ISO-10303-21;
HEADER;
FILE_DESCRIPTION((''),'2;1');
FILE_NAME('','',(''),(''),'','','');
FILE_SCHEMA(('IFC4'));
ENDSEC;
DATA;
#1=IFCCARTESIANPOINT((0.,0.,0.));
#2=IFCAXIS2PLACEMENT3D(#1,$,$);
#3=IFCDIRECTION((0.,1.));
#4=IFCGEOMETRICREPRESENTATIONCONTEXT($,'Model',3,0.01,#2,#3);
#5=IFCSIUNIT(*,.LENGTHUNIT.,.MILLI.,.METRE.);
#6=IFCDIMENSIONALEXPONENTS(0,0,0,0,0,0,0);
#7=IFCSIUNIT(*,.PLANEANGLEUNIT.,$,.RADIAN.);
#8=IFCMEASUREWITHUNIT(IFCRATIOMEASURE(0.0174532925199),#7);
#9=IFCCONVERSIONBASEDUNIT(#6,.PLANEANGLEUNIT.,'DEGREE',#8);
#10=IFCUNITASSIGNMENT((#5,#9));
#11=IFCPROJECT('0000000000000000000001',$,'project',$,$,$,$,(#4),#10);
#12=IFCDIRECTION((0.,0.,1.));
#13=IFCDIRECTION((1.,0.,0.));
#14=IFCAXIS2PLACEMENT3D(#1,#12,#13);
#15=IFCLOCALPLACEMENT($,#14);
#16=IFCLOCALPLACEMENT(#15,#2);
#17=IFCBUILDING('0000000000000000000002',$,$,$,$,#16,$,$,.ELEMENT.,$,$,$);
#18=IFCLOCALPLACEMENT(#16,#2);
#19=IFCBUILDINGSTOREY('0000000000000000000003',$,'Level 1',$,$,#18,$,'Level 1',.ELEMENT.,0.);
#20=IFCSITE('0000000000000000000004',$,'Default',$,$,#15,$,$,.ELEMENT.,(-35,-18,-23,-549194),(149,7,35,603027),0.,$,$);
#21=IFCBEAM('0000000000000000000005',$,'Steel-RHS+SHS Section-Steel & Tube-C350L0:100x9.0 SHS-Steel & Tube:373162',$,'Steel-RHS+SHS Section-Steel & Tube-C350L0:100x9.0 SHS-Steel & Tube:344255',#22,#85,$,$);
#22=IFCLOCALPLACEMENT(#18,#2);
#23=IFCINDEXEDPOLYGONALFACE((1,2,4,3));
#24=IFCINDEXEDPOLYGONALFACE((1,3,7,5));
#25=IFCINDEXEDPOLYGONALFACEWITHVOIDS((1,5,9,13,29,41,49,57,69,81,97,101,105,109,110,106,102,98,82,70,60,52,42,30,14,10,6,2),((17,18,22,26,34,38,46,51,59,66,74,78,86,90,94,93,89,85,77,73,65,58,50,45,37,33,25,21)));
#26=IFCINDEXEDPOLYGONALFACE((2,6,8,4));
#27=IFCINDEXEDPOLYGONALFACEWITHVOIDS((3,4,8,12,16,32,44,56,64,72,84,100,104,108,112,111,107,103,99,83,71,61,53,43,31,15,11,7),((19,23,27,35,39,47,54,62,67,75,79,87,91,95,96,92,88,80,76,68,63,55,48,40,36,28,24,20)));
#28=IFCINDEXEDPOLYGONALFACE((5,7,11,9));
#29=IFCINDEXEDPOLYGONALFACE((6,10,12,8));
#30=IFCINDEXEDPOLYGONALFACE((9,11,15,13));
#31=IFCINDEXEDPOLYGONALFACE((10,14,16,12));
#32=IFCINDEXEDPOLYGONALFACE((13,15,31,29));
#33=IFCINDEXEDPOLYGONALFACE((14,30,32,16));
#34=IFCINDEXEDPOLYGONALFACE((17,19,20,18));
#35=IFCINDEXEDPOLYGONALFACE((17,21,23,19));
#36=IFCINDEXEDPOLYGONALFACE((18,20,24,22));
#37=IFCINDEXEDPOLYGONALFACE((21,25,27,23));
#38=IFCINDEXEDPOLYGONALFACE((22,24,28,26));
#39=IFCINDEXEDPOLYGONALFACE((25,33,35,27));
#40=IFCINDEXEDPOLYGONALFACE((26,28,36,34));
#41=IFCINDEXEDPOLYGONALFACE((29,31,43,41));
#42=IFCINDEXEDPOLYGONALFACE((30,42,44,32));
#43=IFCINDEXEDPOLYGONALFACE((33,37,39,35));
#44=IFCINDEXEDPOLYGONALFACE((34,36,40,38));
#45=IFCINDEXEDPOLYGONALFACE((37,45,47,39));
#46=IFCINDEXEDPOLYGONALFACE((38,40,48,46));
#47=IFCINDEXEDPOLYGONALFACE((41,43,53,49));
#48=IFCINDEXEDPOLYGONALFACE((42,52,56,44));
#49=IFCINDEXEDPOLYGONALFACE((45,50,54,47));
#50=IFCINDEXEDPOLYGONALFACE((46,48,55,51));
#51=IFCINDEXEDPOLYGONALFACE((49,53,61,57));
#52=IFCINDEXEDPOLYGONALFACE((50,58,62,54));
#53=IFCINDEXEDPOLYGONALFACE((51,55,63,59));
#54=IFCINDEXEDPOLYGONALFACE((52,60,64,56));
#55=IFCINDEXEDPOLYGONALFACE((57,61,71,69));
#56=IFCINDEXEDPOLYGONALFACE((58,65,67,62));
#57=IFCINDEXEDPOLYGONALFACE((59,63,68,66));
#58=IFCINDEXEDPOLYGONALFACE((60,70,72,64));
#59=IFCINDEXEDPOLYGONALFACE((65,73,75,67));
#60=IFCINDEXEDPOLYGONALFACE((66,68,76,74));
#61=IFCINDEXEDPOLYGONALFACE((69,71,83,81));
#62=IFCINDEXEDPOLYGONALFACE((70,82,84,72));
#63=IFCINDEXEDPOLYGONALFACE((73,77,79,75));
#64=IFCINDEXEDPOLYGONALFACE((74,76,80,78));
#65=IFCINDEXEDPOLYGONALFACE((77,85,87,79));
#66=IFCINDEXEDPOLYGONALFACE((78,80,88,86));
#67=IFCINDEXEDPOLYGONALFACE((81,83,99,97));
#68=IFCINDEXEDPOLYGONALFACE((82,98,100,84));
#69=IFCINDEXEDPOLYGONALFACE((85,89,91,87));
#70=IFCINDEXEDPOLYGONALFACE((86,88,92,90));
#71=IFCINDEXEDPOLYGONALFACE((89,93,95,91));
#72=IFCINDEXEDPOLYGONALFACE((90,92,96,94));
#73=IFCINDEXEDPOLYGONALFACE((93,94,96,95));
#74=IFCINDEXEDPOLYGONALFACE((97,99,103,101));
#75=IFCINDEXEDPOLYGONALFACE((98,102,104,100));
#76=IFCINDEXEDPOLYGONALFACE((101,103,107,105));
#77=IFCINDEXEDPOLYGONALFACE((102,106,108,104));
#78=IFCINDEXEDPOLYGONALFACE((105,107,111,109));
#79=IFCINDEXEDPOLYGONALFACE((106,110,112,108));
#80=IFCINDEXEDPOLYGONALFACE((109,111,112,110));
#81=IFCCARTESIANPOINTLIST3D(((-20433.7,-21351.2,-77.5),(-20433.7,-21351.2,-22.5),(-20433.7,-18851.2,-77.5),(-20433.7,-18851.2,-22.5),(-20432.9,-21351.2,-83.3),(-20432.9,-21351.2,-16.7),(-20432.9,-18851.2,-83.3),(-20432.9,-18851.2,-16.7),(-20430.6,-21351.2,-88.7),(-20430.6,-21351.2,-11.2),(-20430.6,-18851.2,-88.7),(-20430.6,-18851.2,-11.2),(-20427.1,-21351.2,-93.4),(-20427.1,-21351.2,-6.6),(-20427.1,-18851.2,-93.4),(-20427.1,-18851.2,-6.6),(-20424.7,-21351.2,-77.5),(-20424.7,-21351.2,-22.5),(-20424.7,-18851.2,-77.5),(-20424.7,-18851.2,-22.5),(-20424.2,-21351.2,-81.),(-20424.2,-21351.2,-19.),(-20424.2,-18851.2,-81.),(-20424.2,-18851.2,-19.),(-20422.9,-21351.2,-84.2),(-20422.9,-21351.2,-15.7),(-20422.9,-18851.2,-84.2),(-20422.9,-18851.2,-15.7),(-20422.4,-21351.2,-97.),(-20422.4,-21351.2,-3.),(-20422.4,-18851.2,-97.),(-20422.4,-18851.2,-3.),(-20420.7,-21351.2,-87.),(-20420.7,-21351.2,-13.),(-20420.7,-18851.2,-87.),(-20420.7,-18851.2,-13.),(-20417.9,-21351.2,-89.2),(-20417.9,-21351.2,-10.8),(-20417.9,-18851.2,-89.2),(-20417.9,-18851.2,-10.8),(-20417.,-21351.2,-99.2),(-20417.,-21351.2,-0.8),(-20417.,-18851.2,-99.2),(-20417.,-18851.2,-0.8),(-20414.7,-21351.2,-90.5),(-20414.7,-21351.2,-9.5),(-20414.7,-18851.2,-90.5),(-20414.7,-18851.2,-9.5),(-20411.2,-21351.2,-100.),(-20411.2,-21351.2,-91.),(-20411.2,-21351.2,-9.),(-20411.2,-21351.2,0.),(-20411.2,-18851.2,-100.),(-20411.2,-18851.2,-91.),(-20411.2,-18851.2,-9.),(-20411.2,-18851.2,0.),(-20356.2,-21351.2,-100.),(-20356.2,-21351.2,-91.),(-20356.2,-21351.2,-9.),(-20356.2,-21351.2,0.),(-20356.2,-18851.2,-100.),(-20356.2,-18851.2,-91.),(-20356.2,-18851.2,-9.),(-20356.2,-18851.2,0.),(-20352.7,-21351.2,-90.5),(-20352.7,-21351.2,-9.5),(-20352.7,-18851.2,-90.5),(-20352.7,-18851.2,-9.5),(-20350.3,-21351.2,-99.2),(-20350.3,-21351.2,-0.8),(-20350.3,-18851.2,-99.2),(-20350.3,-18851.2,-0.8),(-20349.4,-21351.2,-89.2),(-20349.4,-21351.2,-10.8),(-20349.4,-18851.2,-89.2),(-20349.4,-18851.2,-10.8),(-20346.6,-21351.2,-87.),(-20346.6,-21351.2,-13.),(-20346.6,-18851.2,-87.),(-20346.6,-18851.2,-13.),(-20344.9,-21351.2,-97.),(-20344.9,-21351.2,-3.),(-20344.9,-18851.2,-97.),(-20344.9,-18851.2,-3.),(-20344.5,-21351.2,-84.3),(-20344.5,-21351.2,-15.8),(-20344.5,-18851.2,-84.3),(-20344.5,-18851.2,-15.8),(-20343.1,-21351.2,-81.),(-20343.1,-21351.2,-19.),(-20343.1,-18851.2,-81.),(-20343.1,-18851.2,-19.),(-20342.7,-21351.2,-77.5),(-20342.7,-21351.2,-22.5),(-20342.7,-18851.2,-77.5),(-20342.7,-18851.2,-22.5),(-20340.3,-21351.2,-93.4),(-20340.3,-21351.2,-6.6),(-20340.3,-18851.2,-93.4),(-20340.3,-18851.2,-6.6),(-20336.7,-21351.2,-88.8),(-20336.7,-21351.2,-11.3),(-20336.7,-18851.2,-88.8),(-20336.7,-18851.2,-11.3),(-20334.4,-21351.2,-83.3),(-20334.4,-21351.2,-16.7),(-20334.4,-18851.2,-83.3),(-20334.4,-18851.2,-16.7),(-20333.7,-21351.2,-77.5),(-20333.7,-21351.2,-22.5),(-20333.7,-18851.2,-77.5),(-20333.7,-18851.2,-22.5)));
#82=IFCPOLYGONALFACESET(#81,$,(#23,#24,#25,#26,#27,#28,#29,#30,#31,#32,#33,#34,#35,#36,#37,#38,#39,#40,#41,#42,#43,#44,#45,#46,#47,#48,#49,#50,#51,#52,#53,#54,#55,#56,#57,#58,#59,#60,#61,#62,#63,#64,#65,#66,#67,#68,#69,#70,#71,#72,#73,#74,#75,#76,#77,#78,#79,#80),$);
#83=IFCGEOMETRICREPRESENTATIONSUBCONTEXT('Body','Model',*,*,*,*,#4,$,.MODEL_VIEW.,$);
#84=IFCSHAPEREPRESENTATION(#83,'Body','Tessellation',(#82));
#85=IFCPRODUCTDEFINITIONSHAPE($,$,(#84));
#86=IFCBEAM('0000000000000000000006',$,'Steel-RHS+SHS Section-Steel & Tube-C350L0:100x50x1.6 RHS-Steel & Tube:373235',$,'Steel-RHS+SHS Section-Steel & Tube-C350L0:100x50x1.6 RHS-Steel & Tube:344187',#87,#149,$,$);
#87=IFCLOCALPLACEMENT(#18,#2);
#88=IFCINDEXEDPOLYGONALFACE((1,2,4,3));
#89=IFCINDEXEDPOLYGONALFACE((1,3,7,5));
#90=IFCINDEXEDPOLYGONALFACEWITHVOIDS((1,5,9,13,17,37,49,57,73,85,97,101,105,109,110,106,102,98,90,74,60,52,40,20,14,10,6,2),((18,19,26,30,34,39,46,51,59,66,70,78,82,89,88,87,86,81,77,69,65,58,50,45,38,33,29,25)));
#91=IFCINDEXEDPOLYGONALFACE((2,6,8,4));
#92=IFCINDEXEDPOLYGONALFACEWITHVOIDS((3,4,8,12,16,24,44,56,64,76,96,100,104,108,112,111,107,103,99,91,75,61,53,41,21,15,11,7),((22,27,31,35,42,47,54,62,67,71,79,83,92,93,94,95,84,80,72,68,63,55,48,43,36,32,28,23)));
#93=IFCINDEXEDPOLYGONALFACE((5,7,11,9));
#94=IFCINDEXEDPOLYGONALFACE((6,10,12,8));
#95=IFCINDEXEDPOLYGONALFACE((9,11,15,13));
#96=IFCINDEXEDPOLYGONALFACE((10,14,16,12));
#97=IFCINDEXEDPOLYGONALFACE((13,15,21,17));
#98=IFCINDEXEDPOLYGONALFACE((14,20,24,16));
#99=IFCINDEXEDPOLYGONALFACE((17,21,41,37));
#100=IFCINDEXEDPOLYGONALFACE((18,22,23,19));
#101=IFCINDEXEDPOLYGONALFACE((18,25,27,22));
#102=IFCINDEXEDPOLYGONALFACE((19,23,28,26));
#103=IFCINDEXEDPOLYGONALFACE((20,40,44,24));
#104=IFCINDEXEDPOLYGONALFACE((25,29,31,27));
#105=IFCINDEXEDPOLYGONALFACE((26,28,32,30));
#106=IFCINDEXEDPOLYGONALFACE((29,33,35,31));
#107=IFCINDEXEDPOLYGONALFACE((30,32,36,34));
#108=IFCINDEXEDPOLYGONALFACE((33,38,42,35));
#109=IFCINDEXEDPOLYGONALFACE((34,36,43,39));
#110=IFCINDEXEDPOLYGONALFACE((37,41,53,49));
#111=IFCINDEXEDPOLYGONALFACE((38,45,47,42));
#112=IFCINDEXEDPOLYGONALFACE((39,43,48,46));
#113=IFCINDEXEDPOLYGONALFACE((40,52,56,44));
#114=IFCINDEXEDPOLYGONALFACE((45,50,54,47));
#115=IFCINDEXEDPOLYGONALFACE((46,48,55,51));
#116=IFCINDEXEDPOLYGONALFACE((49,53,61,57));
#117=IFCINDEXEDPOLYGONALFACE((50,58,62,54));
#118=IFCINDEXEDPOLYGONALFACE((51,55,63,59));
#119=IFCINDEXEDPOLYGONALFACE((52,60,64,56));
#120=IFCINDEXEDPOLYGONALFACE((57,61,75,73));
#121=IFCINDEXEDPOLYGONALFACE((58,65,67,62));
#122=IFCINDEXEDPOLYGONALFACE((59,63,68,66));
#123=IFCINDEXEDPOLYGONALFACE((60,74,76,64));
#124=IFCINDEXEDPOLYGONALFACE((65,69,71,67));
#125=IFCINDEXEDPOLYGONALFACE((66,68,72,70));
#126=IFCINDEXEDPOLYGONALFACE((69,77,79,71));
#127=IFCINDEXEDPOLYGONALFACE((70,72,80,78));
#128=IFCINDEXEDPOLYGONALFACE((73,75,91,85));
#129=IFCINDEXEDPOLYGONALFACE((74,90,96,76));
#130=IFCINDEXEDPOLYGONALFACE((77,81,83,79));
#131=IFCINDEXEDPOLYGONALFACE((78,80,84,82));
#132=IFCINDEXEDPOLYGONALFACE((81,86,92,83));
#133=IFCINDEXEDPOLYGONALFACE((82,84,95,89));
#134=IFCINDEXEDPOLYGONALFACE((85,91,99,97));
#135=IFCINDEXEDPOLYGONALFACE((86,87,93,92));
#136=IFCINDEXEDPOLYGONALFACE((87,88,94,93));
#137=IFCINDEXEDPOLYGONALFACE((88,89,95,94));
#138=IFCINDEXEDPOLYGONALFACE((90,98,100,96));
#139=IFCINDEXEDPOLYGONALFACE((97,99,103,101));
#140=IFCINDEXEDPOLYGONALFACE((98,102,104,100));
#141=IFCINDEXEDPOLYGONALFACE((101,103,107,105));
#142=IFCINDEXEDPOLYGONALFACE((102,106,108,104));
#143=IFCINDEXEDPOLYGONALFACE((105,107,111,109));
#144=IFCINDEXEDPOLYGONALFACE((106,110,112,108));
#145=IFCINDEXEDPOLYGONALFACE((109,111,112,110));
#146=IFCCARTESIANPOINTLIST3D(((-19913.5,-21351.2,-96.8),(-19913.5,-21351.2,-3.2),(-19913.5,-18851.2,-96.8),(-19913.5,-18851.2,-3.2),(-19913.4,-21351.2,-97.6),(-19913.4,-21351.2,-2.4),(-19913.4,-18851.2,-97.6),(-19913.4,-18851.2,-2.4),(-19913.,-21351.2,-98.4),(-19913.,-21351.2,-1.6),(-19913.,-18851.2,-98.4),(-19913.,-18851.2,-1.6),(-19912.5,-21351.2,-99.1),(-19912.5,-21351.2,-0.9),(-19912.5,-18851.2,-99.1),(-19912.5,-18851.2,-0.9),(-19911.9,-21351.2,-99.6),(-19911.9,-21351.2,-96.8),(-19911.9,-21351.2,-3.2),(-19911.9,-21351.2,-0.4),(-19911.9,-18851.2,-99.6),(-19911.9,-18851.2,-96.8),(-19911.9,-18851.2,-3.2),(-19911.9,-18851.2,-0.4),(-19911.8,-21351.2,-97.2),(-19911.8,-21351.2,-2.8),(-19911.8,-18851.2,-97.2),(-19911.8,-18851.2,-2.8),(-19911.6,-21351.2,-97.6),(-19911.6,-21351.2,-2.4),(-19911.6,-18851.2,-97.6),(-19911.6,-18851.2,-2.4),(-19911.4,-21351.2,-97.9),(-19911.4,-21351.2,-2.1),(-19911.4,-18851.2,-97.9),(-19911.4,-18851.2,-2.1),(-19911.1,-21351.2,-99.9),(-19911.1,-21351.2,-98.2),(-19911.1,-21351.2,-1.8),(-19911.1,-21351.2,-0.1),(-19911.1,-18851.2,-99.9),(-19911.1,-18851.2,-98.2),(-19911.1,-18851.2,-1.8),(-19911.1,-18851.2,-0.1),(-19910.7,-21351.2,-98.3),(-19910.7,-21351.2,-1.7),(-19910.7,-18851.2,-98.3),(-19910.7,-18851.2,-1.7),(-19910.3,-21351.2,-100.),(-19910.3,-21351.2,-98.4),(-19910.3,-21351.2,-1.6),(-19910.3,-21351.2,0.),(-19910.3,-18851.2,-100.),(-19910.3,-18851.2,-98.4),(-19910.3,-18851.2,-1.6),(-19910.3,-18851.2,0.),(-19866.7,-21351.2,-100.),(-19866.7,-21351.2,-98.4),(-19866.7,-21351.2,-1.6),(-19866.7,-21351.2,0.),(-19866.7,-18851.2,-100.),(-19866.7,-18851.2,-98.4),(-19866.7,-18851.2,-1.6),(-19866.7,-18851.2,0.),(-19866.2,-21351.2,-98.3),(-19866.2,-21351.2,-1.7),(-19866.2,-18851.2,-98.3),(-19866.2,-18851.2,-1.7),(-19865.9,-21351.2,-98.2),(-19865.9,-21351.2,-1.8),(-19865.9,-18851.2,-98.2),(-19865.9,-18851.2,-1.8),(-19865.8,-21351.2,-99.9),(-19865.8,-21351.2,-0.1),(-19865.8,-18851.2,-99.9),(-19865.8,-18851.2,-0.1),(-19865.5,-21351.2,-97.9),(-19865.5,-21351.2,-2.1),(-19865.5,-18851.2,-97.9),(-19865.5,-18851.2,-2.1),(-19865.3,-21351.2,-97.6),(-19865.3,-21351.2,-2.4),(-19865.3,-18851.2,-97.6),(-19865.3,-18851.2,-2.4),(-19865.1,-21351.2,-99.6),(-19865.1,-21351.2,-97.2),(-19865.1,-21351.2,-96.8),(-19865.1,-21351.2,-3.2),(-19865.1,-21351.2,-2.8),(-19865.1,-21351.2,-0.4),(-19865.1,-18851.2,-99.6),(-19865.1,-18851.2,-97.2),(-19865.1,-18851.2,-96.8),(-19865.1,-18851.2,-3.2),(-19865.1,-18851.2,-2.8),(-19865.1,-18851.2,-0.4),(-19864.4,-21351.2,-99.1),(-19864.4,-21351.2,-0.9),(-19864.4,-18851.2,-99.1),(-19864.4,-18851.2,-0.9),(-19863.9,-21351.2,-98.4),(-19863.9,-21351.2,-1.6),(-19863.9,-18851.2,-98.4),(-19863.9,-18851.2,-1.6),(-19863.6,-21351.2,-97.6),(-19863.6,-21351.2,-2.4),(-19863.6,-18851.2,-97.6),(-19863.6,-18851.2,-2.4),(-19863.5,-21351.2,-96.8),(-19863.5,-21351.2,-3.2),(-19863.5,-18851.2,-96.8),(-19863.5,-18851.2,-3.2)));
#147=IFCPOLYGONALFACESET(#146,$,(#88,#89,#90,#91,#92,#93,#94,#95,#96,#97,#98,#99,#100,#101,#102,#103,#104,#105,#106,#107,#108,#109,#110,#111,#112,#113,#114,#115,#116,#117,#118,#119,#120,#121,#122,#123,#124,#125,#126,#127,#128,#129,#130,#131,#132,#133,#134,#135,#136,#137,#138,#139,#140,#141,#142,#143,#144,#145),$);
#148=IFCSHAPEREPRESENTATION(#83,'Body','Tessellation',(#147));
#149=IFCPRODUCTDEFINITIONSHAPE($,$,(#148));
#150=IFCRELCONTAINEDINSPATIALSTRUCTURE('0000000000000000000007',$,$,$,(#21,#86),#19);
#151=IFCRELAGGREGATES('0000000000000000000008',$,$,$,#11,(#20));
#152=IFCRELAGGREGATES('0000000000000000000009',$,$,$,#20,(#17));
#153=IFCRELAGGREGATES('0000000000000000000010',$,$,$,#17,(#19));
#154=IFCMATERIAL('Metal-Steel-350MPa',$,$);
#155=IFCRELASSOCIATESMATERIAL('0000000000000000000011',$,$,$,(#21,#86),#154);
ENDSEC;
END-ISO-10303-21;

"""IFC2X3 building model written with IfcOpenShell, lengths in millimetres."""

from ifc_helpers import new_model, entity, si_unit, converted_unit, direction, frame, frame_2d, origin, origin_with_axes, place, context, subcontext, project, spatial, polyline, circle_curve, parameter, trimmed, segment, composite_curve, outline, extrude, material, element, save


model = new_model("IFC2X3")

# Units and contexts
model_context = context("Model", 3, precision=0.01, world=origin(), true_north=direction((0.0, 1.0)))
body_context = subcontext(model_context, "Body", "Model", "MODEL_VIEW")
ifc_project = project(units=[si_unit("LENGTHUNIT", "METRE", prefix="MILLI"), converted_unit("PLANEANGLEUNIT", "DEGREE", entity("IfcRatioMeasure", 0.0174532925199), si_unit("PLANEANGLEUNIT", "RADIAN"), dimensions=[0, 0, 0, 0, 0, 0, 0])], contexts=[model_context])

# Site, building, storey
site_placement = place(None, origin_with_axes())
site = spatial("IfcSite", under=ifc_project, at=site_placement, Name="Default", CompositionType="ELEMENT", RefLatitude=(-35, -18, -23, -549194), RefLongitude=(149, 7, 35, 603027), RefElevation=0.0)
building_placement = place(site_placement, origin())
building = spatial("IfcBuilding", under=site, at=building_placement, CompositionType="ELEMENT")
storey_placement = place(building_placement, origin())
storey = spatial("IfcBuildingStorey", under=building, at=storey_placement, Name="Level 1", LongName="Level 1", CompositionType="ELEMENT", Elevation=0.0)

# Beams
ifc_material = material(Name="Metal-Steel-350MPa")
beam_1_placement = place(storey_placement, frame((-20383.7, -18851.2, 0.0), z_axis=(0.0, 0.0, 1.0), x_axis=(0.0, -1.0, 0.0)))
element("IfcBeam", 1, at=beam_1_placement, inside=storey, material=ifc_material, Name="Steel-RHS+SHS Section-Steel & Tube-C350L0:100x9.0 SHS-Steel & Tube:373162", ObjectType="Steel-RHS+SHS Section-Steel & Tube-C350L0:100x9.0 SHS-Steel & Tube:344255", context=body_context, shape_type="SweptSolid", body=[
    extrude(outline(composite_curve([segment(trimmed(circle_curve(frame_2d((-27.5, -27.5), x_axis=(1.0, 0.0)), 22.5), [parameter(180.0)], [parameter(270.0)], True, "PARAMETER"), True, "CONTINUOUS"), segment(polyline([(-27.5, -50.0), (27.5, -50.0)]), True, "CONTINUOUS"), segment(trimmed(circle_curve(frame_2d((27.5, -27.5), x_axis=(1.0, 0.0)), 22.5), [parameter(270.0)], [parameter(0.0)], True, "PARAMETER"), True, "CONTINUOUS"), segment(polyline([(50.0, -27.5), (50.0, 27.5)]), True, "CONTINUOUS"), segment(trimmed(circle_curve(frame_2d((27.5, 27.5), x_axis=(1.0, 0.0)), 22.5), [parameter(0.0)], [parameter(90.0)], True, "PARAMETER"), True, "CONTINUOUS"), segment(polyline([(27.5, 50.0), (-27.5, 50.0)]), True, "CONTINUOUS"), segment(trimmed(circle_curve(frame_2d((-27.5, 27.5), x_axis=(1.0, 0.0)), 22.5), [parameter(90.0)], [parameter(180.0)], True, "PARAMETER"), True, "CONTINUOUS"), segment(polyline([(-50.0, 27.5), (-50.0, -27.5)]), True, "CONTINUOUS")], self_intersect=False), holes=[composite_curve([segment(polyline([(27.5, -41.0), (-27.5, -41.0)]), True, "CONTINUOUS"), segment(trimmed(circle_curve(frame_2d((-27.5, -27.5), x_axis=(1.0, 0.0)), 13.5), [parameter(180.0)], [parameter(270.0)], True, "PARAMETER"), False, "CONTINUOUS"), segment(polyline([(-41.0, -27.5), (-41.0, 27.5)]), True, "CONTINUOUS"), segment(trimmed(circle_curve(frame_2d((-27.5, 27.5), x_axis=(1.0, 0.0)), 13.5), [parameter(90.0)], [parameter(180.0)], True, "PARAMETER"), False, "CONTINUOUS"), segment(polyline([(-27.5, 41.0), (27.5, 41.0)]), True, "CONTINUOUS"), segment(trimmed(circle_curve(frame_2d((27.5, 27.5), x_axis=(1.0, 0.0)), 13.5), [parameter(360.0)], [parameter(90.0)], True, "PARAMETER"), False, "CONTINUOUS"), segment(polyline([(41.0, 27.5), (41.0, -27.5)]), True, "CONTINUOUS"), segment(trimmed(circle_curve(frame_2d((27.5, -27.5), x_axis=(1.0, 0.0)), 13.5), [parameter(270.0)], [parameter(0.0)], True, "PARAMETER"), False, "CONTINUOUS")], self_intersect=False)]), frame((0.0, 0.0, -50.0), z_axis=(1.0, 0.0, 0.0), x_axis=(0.0, -1.0, 0.0)), (0.0, 0.0, 1.0), 2500.0),
])
beam_2_placement = place(storey_placement, frame((-19888.5, -18851.2, 0.0), z_axis=(0.0, 0.0, 1.0), x_axis=(0.0, -1.0, 0.0)))
element("IfcBeam", 2, at=beam_2_placement, inside=storey, material=ifc_material, Name="Steel-RHS+SHS Section-Steel & Tube-C350L0:100x50x1.6 RHS-Steel & Tube:373235", ObjectType="Steel-RHS+SHS Section-Steel & Tube-C350L0:100x50x1.6 RHS-Steel & Tube:344187", context=body_context, shape_type="SweptSolid", body=[
    extrude(outline(composite_curve([segment(trimmed(circle_curve(frame_2d((-21.8, -46.8), x_axis=(1.0, 0.0)), 3.2), [parameter(180.0)], [parameter(270.0)], True, "PARAMETER"), True, "CONTINUOUS"), segment(polyline([(-21.8, -50.0), (21.8, -50.0)]), True, "CONTINUOUS"), segment(trimmed(circle_curve(frame_2d((21.8, -46.8), x_axis=(1.0, 0.0)), 3.2), [parameter(270.0)], [parameter(0.0)], True, "PARAMETER"), True, "CONTINUOUS"), segment(polyline([(25.0, -46.8), (25.0, 46.8)]), True, "CONTINUOUS"), segment(trimmed(circle_curve(frame_2d((21.8, 46.8), x_axis=(1.0, 0.0)), 3.2), [parameter(0.0)], [parameter(90.0)], True, "PARAMETER"), True, "CONTINUOUS"), segment(polyline([(21.8, 50.0), (-21.8, 50.0)]), True, "CONTINUOUS"), segment(trimmed(circle_curve(frame_2d((-21.8, 46.8), x_axis=(1.0, 0.0)), 3.2), [parameter(90.0)], [parameter(180.0)], True, "PARAMETER"), True, "CONTINUOUS"), segment(polyline([(-25.0, 46.8), (-25.0, -46.8)]), True, "CONTINUOUS")], self_intersect=False), holes=[composite_curve([segment(polyline([(21.8, -48.4), (-21.8, -48.4)]), True, "CONTINUOUS"), segment(trimmed(circle_curve(frame_2d((-21.8, -46.8), x_axis=(1.0, 0.0)), 1.6), [parameter(180.0)], [parameter(270.0)], True, "PARAMETER"), False, "CONTINUOUS"), segment(polyline([(-23.4, -46.8), (-23.4, 46.8)]), True, "CONTINUOUS"), segment(trimmed(circle_curve(frame_2d((-21.8, 46.8), x_axis=(1.0, 0.0)), 1.6), [parameter(90.0)], [parameter(180.0)], True, "PARAMETER"), False, "CONTINUOUS"), segment(polyline([(-21.8, 48.4), (21.8, 48.4)]), True, "CONTINUOUS"), segment(trimmed(circle_curve(frame_2d((21.8, 46.8), x_axis=(1.0, 0.0)), 1.6), [parameter(360.0)], [parameter(90.0)], True, "PARAMETER"), False, "CONTINUOUS"), segment(polyline([(23.4, 46.8), (23.4, -46.8)]), True, "CONTINUOUS"), segment(trimmed(circle_curve(frame_2d((21.8, -46.8), x_axis=(1.0, 0.0)), 1.6), [parameter(270.0)], [parameter(0.0)], True, "PARAMETER"), False, "CONTINUOUS")], self_intersect=False)]), frame((0.0, 0.0, -50.0), z_axis=(1.0, 0.0, 0.0), x_axis=(0.0, -1.0, 0.0)), (0.0, 0.0, 1.0), 2500.0),
])

save(model, "model.ifc")
